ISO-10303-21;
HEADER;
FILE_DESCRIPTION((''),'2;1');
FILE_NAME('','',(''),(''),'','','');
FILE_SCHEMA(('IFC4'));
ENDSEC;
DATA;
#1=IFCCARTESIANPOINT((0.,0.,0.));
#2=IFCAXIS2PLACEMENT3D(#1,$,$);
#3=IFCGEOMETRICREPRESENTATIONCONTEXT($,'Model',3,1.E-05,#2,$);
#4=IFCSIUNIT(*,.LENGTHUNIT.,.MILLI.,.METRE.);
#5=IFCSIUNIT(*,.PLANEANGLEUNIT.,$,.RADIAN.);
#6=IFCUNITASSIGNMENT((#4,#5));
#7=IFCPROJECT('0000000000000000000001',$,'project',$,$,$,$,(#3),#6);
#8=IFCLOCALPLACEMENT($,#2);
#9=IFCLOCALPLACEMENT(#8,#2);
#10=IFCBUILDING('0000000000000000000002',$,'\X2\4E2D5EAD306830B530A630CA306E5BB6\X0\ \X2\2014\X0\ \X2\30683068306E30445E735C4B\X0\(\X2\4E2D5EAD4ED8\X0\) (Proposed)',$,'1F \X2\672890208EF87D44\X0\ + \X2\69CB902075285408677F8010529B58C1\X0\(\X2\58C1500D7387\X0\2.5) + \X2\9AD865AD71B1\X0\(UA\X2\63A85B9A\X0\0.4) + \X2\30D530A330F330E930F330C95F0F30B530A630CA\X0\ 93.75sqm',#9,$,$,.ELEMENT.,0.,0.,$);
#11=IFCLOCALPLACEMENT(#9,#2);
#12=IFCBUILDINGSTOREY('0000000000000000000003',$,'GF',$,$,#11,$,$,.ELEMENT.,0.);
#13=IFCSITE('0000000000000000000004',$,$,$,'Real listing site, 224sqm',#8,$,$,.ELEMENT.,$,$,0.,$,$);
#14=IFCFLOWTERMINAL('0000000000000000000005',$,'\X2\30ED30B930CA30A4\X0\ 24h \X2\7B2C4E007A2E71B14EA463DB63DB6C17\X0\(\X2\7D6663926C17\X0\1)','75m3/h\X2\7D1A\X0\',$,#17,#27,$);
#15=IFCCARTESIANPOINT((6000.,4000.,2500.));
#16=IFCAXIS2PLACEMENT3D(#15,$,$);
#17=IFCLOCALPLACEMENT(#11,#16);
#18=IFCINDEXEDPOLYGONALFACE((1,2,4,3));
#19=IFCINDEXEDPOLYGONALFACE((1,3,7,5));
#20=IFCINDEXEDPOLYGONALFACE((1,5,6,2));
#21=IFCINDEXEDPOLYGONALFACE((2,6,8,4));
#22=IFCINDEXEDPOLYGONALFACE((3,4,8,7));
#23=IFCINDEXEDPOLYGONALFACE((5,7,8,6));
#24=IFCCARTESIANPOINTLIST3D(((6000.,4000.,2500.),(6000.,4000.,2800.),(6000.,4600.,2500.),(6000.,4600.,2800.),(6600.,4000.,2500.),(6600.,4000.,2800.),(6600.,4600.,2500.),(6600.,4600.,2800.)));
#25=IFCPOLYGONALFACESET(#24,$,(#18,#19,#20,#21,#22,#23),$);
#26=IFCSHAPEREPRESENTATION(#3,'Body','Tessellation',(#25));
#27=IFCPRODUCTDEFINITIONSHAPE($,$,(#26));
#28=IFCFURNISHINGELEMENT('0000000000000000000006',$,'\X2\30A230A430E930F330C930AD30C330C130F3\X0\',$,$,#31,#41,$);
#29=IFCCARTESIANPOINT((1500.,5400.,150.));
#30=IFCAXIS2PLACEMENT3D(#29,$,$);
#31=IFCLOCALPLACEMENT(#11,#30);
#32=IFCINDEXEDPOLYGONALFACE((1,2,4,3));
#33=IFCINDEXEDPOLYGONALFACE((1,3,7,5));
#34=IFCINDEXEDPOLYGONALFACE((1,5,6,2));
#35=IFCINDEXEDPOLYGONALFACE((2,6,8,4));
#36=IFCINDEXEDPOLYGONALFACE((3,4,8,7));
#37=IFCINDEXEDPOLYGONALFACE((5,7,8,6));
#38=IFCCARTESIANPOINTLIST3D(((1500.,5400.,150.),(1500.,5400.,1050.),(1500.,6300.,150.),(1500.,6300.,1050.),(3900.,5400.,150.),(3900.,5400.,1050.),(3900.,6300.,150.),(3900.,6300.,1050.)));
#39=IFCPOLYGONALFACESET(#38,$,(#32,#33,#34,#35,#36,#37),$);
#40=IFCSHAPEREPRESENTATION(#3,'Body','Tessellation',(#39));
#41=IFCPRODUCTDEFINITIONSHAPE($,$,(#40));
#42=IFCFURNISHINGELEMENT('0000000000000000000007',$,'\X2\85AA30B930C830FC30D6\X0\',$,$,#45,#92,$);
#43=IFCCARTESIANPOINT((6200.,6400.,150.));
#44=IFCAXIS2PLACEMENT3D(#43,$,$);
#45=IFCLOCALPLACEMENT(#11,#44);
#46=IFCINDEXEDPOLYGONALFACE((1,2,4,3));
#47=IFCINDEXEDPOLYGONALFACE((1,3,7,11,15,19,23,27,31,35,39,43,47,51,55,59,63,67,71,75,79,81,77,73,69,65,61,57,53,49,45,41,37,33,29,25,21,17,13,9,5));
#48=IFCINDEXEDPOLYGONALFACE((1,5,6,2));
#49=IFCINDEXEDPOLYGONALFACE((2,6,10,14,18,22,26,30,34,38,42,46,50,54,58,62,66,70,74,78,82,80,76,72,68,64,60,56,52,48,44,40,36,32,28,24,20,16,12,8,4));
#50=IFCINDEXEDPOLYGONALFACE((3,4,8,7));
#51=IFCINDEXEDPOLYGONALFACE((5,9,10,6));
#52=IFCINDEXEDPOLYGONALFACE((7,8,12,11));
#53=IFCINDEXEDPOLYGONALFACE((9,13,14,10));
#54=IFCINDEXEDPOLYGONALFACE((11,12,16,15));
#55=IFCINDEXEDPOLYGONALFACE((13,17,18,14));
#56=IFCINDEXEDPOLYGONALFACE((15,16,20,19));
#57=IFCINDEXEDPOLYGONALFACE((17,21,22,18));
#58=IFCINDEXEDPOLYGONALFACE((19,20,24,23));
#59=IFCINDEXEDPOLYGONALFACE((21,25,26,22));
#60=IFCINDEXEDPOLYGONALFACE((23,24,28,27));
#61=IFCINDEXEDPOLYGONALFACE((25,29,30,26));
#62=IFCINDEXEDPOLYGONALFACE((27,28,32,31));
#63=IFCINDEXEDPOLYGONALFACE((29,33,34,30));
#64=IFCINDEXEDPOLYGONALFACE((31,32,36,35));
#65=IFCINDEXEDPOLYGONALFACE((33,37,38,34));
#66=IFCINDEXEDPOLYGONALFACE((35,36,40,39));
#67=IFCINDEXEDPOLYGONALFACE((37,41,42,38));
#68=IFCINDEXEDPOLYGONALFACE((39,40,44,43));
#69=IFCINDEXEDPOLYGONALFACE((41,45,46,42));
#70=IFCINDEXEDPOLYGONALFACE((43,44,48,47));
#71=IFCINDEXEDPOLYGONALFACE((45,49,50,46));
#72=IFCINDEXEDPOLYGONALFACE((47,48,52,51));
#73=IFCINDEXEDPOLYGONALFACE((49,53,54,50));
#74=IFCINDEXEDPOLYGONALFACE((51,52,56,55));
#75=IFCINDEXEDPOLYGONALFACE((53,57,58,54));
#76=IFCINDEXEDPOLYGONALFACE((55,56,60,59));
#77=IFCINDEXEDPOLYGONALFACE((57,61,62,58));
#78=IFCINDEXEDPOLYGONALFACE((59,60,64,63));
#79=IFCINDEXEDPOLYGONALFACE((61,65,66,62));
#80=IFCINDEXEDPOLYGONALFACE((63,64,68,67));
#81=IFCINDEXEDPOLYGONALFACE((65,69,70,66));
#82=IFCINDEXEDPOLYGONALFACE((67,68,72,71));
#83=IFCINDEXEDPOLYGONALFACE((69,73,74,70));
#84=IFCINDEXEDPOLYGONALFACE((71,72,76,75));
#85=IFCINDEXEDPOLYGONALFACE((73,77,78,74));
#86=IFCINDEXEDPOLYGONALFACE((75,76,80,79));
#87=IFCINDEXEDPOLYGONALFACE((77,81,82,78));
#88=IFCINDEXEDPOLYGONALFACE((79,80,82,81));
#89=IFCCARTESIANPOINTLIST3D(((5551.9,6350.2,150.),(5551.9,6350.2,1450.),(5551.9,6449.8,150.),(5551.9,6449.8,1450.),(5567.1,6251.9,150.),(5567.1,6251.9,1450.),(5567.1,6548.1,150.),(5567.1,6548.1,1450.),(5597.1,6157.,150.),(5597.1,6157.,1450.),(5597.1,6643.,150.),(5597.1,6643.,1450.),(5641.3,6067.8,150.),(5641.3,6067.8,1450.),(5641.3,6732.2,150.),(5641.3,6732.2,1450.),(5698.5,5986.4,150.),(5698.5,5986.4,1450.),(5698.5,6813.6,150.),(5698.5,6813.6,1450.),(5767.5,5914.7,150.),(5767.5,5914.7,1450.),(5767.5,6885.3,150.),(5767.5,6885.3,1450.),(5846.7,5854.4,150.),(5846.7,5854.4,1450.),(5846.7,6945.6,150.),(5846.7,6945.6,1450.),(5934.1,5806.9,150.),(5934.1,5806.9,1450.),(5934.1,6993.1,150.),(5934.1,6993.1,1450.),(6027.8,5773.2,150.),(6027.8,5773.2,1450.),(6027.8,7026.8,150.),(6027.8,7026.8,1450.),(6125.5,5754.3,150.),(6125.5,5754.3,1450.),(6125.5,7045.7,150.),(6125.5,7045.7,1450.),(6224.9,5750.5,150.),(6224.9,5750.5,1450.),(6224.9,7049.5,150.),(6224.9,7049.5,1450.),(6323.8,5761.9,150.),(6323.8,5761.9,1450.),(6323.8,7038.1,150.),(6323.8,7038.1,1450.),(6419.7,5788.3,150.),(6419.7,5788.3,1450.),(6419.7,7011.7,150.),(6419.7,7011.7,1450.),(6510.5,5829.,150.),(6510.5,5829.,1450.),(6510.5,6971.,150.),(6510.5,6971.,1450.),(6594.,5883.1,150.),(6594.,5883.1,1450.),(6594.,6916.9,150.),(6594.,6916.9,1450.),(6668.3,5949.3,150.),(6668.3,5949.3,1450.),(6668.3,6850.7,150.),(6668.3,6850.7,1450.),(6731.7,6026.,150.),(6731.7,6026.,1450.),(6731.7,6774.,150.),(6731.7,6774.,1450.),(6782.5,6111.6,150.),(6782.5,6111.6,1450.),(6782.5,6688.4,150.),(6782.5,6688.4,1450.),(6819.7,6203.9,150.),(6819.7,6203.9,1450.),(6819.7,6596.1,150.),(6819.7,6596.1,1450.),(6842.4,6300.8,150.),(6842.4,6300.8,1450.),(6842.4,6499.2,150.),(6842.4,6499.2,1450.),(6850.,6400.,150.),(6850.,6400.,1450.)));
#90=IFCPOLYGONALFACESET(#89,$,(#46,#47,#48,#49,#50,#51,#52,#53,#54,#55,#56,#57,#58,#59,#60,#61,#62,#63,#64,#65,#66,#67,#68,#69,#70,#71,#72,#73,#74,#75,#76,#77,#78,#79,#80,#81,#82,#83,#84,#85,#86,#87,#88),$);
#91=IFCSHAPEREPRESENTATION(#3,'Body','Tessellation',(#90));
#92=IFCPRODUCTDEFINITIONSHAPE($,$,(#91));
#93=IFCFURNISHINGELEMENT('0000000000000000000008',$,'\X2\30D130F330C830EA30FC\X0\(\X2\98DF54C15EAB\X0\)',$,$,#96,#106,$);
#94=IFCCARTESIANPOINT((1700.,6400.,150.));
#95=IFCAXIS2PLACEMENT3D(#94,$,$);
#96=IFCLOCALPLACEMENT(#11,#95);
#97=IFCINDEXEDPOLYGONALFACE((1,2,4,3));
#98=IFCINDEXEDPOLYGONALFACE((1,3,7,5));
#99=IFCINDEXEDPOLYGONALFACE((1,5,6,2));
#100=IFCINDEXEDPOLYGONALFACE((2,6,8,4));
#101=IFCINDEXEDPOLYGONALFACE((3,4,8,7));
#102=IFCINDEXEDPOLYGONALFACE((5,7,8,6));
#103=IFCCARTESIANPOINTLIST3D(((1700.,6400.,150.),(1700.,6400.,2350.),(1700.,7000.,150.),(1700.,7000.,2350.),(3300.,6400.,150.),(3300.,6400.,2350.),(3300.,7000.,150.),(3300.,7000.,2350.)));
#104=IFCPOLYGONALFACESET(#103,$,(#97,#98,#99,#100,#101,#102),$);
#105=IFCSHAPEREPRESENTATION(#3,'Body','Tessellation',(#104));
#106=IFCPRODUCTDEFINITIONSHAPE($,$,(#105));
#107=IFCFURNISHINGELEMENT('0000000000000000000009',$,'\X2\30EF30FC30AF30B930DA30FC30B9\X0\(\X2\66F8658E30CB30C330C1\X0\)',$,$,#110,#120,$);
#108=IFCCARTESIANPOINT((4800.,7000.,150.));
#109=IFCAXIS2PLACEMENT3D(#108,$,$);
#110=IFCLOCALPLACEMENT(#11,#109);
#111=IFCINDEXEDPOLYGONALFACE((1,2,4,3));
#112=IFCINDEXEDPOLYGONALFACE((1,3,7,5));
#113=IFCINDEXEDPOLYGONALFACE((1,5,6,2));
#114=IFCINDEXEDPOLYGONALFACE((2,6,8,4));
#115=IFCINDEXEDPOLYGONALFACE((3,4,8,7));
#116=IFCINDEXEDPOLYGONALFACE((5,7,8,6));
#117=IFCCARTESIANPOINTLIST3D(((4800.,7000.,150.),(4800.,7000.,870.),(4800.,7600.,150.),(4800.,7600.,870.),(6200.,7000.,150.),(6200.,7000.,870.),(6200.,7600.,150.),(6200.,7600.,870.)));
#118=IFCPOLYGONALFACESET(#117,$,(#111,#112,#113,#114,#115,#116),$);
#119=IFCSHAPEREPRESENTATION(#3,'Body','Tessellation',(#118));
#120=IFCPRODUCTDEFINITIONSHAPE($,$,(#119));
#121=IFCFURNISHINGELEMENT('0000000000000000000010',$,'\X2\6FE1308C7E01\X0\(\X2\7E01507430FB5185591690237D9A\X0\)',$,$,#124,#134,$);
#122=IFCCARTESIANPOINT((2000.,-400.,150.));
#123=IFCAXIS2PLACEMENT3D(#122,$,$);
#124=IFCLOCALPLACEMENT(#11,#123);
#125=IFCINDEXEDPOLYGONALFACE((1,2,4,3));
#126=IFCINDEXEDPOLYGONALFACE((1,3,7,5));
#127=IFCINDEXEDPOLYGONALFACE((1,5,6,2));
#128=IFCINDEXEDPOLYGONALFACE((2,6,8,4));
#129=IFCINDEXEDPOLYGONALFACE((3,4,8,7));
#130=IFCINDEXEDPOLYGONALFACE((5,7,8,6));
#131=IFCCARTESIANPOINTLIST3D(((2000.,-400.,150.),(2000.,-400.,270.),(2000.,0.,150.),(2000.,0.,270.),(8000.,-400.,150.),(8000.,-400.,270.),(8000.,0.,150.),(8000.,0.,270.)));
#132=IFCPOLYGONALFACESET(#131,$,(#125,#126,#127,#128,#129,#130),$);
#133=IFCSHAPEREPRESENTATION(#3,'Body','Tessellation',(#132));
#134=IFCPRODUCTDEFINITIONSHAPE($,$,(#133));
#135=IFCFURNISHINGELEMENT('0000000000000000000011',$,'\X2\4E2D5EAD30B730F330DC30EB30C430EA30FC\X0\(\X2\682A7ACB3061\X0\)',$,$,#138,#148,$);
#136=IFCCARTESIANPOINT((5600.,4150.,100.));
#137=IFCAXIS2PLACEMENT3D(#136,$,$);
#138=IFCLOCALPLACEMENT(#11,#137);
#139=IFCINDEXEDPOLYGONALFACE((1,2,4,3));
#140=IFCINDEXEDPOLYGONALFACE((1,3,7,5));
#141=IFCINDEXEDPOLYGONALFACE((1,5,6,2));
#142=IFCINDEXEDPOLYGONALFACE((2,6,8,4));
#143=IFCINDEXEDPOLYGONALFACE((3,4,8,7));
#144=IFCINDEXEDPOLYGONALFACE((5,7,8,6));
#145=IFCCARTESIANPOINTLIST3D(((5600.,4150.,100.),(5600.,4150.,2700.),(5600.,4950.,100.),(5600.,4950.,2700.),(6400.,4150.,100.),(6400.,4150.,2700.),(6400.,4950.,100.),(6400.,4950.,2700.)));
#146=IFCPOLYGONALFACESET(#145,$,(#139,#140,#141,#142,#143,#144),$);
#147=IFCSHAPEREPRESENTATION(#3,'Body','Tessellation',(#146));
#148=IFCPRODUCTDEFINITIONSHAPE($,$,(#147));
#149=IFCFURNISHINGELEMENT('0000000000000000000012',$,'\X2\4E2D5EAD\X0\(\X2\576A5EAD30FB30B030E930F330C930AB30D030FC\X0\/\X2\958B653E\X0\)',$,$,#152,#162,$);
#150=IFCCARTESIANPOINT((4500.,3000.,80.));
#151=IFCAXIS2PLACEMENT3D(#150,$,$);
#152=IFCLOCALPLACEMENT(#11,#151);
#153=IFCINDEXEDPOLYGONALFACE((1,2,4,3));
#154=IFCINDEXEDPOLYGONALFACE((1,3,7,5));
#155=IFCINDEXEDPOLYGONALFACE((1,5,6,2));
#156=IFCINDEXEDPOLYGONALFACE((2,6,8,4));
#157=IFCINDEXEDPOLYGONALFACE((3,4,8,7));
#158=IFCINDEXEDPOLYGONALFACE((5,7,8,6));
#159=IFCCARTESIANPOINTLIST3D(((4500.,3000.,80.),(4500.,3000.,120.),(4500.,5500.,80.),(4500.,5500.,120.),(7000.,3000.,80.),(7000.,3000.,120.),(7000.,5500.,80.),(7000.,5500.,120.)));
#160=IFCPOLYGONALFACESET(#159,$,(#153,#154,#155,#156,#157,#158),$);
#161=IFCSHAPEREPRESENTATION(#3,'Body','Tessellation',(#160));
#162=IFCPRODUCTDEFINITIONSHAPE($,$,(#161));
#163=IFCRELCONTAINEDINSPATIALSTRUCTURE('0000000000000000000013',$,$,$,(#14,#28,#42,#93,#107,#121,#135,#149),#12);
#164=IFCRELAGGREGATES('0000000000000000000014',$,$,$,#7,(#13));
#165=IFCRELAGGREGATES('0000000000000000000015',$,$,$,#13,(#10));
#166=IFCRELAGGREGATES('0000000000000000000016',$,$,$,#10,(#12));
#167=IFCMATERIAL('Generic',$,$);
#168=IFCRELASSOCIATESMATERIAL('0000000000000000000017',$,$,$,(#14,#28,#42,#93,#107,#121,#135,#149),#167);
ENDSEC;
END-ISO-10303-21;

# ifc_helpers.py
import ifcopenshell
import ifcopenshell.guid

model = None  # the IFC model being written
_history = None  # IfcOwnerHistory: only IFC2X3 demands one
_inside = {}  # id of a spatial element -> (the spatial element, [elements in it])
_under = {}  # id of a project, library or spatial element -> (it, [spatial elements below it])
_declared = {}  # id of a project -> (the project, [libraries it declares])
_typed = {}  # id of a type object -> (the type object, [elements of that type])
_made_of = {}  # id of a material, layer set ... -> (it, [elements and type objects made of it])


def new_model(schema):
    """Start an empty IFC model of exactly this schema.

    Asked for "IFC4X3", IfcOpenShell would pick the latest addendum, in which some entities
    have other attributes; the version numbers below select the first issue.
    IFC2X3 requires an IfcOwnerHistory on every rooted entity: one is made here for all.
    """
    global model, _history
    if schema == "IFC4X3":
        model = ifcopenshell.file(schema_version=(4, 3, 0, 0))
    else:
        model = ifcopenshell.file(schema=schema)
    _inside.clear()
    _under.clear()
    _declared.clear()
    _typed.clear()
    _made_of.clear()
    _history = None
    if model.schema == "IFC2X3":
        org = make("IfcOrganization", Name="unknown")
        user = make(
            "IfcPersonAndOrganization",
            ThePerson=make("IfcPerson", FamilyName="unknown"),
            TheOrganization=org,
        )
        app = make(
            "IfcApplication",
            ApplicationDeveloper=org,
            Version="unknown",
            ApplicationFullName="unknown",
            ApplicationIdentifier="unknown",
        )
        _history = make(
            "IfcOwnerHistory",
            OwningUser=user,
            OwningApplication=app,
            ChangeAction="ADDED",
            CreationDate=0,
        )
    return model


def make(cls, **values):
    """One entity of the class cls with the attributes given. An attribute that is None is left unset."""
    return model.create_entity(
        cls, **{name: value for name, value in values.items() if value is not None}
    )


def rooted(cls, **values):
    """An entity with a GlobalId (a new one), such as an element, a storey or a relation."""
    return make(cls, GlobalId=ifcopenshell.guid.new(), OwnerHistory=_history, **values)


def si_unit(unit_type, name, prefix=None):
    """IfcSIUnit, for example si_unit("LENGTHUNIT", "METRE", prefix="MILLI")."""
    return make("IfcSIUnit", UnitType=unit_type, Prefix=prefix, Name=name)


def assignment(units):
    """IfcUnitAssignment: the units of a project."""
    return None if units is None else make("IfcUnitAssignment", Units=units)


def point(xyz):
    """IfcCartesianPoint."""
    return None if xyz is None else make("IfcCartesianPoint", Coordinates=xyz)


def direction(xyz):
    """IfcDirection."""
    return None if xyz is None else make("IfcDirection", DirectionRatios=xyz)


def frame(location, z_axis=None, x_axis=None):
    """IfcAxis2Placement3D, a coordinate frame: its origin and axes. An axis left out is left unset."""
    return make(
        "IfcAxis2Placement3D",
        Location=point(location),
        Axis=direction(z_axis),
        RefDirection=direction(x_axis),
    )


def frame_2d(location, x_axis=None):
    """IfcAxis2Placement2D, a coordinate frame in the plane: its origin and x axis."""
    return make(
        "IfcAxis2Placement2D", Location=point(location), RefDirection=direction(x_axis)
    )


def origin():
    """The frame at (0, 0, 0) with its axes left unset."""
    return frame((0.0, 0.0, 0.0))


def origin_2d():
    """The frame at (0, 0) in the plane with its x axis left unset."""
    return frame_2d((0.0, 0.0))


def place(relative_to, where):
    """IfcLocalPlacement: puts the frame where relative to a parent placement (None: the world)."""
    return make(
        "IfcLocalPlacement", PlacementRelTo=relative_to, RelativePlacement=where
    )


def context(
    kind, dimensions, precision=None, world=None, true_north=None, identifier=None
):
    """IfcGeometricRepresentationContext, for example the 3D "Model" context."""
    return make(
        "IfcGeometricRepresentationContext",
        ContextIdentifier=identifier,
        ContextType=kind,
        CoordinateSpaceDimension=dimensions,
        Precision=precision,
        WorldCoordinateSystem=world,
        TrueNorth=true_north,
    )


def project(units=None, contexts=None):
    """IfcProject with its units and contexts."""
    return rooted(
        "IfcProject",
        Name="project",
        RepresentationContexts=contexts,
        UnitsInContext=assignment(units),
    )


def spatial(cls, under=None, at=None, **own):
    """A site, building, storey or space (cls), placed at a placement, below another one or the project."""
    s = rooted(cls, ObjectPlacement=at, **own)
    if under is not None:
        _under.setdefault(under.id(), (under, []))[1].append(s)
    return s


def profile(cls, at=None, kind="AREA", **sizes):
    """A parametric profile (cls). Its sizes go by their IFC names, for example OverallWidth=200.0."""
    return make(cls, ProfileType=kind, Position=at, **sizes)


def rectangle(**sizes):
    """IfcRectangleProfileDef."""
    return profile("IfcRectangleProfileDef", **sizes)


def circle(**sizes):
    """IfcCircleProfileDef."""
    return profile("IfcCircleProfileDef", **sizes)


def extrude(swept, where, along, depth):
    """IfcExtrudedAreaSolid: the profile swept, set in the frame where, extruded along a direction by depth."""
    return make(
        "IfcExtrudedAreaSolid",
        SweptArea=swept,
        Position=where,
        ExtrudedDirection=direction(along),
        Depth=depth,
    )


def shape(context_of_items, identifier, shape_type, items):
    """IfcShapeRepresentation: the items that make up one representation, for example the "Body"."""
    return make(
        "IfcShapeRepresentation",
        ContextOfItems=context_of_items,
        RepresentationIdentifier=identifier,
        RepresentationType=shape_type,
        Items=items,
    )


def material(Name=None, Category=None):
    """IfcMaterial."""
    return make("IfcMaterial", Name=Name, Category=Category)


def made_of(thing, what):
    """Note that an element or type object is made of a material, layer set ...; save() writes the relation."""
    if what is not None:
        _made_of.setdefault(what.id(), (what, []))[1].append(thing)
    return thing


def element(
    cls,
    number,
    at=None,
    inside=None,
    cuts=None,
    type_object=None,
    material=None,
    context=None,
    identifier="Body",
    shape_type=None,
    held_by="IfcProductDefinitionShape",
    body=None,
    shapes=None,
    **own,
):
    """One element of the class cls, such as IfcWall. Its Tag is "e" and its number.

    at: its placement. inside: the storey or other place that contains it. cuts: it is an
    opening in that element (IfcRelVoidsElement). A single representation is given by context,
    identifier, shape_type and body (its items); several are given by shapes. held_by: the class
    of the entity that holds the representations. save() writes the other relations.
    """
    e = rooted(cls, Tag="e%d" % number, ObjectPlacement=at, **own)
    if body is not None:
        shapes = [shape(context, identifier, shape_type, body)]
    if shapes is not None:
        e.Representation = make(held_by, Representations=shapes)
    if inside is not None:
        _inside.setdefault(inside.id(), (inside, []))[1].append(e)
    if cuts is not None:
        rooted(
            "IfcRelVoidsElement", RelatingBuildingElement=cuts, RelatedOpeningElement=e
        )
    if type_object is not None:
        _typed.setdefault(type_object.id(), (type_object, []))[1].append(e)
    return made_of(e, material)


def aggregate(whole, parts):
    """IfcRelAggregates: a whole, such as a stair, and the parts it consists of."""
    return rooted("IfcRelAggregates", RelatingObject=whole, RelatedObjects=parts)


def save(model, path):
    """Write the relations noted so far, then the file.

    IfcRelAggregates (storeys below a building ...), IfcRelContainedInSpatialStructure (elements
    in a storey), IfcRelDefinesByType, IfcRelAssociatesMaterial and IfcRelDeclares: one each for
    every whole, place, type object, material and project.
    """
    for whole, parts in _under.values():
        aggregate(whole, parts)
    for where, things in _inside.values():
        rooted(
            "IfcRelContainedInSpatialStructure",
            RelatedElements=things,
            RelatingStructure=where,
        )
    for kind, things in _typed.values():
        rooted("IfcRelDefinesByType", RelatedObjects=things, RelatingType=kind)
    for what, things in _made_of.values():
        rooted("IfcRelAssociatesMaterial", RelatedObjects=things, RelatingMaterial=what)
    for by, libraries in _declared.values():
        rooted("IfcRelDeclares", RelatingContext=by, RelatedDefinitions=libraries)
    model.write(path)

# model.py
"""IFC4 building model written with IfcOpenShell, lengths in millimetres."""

from ifc_helpers import new_model, si_unit, frame, frame_2d, origin, origin_2d, place, context, project, spatial, rectangle, circle, extrude, material, element, save


model = new_model("IFC4")

# Units and contexts
model_context = context("Model", 3, precision=1e-05, world=origin())
ifc_project = project(units=[si_unit("LENGTHUNIT", "METRE", prefix="MILLI"), si_unit("PLANEANGLEUNIT", "RADIAN")], contexts=[model_context])

# Site, building, storey
site_placement = place(None, origin())
site = spatial("IfcSite", under=ifc_project, at=site_placement, ObjectType="Real listing site, 224sqm", CompositionType="ELEMENT", RefElevation=0.0)
building_placement = place(site_placement, origin())
building = spatial("IfcBuilding", under=site, at=building_placement, Name="中庭とサウナの家 — ととのい平屋(中庭付) (Proposed)", ObjectType="1F 木造軸組 + 構造用合板耐力壁(壁倍率2.5) + 高断熱(UA推定0.4) + フィンランド式サウナ 93.75sqm", CompositionType="ELEMENT", ElevationOfRefHeight=0.0, ElevationOfTerrain=0.0)
storey_placement = place(building_placement, origin())
storey = spatial("IfcBuildingStorey", under=building, at=storey_placement, Name="GF", CompositionType="ELEMENT", Elevation=0.0)

# Shared definitions
ifc_material = material(Name="Generic")

# Flow terminal
flow_terminal_placement = place(storey_placement, frame((6000.0, 4000.0, 2500.0)))
element("IfcFlowTerminal", 1, at=flow_terminal_placement, inside=storey, material=ifc_material, Name="ロスナイ 24h 第一種熱交換換気(給排気1)", Description="75m3/h級", context=model_context, shape_type="SweptSolid", body=[
    extrude(rectangle(XDim=600.0, YDim=600.0, at=frame_2d((300.0, 300.0))), frame((6000.0, 4000.0, 2500.0)), (0.0, 0.0, 1.0), 300.0),
])

# Furnishing elements
furnishing_1_placement = place(storey_placement, frame((1500.0, 5400.0, 150.0)))
element("IfcFurnishingElement", 2, at=furnishing_1_placement, inside=storey, material=ifc_material, Name="アイランドキッチン", context=model_context, shape_type="SweptSolid", body=[
    extrude(rectangle(XDim=2400.0, YDim=900.0, at=frame_2d((1200.0, 450.0))), frame((1500.0, 5400.0, 150.0)), (0.0, 0.0, 1.0), 900.0),
])
furnishing_2_placement = place(storey_placement, frame((6200.0, 6400.0, 150.0)))
element("IfcFurnishingElement", 3, at=furnishing_2_placement, inside=storey, material=ifc_material, Name="薪ストーブ", context=model_context, shape_type="SweptSolid", body=[
    extrude(circle(Radius=650.0, at=origin_2d()), frame((6200.0, 6400.0, 150.0)), (0.0, 0.0, 1.0), 1300.0),
])
furnishing_3_placement = place(storey_placement, frame((1700.0, 6400.0, 150.0)))
element("IfcFurnishingElement", 4, at=furnishing_3_placement, inside=storey, material=ifc_material, Name="パントリー(食品庫)", context=model_context, shape_type="SweptSolid", body=[
    extrude(rectangle(XDim=1600.0, YDim=600.0, at=frame_2d((800.0, 300.0))), frame((1700.0, 6400.0, 150.0)), (0.0, 0.0, 1.0), 2200.0),
])
furnishing_4_placement = place(storey_placement, frame((4800.0, 7000.0, 150.0)))
element("IfcFurnishingElement", 5, at=furnishing_4_placement, inside=storey, material=ifc_material, Name="ワークスペース(書斎ニッチ)", context=model_context, shape_type="SweptSolid", body=[
    extrude(rectangle(XDim=1400.0, YDim=600.0, at=frame_2d((700.0, 300.0))), frame((4800.0, 7000.0, 150.0)), (0.0, 0.0, 1.0), 720.0),
])
furnishing_5_placement = place(storey_placement, frame((2000.0, -400.0, 150.0)))
element("IfcFurnishingElement", 6, at=furnishing_5_placement, inside=storey, material=ifc_material, Name="濡れ縁(縁側・内外連続)", context=model_context, shape_type="SweptSolid", body=[
    extrude(rectangle(XDim=6000.0, YDim=400.0, at=frame_2d((3000.0, 200.0))), frame((2000.0, -400.0, 150.0)), (0.0, 0.0, 1.0), 120.0),
])
furnishing_6_placement = place(storey_placement, frame((5600.0, 4150.0, 100.0)))
element("IfcFurnishingElement", 7, at=furnishing_6_placement, inside=storey, material=ifc_material, Name="中庭シンボルツリー(株立ち)", context=model_context, shape_type="SweptSolid", body=[
    extrude(rectangle(XDim=800.0, YDim=800.0, at=frame_2d((400.0, 400.0))), frame((5600.0, 4150.0, 100.0)), (0.0, 0.0, 1.0), 2600.0),
])
furnishing_7_placement = place(storey_placement, frame((4500.0, 3000.0, 80.0)))
element("IfcFurnishingElement", 8, at=furnishing_7_placement, inside=storey, material=ifc_material, Name="中庭(坪庭・グランドカバー/開放)", context=model_context, shape_type="SweptSolid", body=[
    extrude(rectangle(XDim=2500.0, YDim=2500.0, at=frame_2d((1250.0, 1250.0))), frame((4500.0, 3000.0, 80.0)), (0.0, 0.0, 1.0), 40.0),
])

save(model, "model.ifc")
